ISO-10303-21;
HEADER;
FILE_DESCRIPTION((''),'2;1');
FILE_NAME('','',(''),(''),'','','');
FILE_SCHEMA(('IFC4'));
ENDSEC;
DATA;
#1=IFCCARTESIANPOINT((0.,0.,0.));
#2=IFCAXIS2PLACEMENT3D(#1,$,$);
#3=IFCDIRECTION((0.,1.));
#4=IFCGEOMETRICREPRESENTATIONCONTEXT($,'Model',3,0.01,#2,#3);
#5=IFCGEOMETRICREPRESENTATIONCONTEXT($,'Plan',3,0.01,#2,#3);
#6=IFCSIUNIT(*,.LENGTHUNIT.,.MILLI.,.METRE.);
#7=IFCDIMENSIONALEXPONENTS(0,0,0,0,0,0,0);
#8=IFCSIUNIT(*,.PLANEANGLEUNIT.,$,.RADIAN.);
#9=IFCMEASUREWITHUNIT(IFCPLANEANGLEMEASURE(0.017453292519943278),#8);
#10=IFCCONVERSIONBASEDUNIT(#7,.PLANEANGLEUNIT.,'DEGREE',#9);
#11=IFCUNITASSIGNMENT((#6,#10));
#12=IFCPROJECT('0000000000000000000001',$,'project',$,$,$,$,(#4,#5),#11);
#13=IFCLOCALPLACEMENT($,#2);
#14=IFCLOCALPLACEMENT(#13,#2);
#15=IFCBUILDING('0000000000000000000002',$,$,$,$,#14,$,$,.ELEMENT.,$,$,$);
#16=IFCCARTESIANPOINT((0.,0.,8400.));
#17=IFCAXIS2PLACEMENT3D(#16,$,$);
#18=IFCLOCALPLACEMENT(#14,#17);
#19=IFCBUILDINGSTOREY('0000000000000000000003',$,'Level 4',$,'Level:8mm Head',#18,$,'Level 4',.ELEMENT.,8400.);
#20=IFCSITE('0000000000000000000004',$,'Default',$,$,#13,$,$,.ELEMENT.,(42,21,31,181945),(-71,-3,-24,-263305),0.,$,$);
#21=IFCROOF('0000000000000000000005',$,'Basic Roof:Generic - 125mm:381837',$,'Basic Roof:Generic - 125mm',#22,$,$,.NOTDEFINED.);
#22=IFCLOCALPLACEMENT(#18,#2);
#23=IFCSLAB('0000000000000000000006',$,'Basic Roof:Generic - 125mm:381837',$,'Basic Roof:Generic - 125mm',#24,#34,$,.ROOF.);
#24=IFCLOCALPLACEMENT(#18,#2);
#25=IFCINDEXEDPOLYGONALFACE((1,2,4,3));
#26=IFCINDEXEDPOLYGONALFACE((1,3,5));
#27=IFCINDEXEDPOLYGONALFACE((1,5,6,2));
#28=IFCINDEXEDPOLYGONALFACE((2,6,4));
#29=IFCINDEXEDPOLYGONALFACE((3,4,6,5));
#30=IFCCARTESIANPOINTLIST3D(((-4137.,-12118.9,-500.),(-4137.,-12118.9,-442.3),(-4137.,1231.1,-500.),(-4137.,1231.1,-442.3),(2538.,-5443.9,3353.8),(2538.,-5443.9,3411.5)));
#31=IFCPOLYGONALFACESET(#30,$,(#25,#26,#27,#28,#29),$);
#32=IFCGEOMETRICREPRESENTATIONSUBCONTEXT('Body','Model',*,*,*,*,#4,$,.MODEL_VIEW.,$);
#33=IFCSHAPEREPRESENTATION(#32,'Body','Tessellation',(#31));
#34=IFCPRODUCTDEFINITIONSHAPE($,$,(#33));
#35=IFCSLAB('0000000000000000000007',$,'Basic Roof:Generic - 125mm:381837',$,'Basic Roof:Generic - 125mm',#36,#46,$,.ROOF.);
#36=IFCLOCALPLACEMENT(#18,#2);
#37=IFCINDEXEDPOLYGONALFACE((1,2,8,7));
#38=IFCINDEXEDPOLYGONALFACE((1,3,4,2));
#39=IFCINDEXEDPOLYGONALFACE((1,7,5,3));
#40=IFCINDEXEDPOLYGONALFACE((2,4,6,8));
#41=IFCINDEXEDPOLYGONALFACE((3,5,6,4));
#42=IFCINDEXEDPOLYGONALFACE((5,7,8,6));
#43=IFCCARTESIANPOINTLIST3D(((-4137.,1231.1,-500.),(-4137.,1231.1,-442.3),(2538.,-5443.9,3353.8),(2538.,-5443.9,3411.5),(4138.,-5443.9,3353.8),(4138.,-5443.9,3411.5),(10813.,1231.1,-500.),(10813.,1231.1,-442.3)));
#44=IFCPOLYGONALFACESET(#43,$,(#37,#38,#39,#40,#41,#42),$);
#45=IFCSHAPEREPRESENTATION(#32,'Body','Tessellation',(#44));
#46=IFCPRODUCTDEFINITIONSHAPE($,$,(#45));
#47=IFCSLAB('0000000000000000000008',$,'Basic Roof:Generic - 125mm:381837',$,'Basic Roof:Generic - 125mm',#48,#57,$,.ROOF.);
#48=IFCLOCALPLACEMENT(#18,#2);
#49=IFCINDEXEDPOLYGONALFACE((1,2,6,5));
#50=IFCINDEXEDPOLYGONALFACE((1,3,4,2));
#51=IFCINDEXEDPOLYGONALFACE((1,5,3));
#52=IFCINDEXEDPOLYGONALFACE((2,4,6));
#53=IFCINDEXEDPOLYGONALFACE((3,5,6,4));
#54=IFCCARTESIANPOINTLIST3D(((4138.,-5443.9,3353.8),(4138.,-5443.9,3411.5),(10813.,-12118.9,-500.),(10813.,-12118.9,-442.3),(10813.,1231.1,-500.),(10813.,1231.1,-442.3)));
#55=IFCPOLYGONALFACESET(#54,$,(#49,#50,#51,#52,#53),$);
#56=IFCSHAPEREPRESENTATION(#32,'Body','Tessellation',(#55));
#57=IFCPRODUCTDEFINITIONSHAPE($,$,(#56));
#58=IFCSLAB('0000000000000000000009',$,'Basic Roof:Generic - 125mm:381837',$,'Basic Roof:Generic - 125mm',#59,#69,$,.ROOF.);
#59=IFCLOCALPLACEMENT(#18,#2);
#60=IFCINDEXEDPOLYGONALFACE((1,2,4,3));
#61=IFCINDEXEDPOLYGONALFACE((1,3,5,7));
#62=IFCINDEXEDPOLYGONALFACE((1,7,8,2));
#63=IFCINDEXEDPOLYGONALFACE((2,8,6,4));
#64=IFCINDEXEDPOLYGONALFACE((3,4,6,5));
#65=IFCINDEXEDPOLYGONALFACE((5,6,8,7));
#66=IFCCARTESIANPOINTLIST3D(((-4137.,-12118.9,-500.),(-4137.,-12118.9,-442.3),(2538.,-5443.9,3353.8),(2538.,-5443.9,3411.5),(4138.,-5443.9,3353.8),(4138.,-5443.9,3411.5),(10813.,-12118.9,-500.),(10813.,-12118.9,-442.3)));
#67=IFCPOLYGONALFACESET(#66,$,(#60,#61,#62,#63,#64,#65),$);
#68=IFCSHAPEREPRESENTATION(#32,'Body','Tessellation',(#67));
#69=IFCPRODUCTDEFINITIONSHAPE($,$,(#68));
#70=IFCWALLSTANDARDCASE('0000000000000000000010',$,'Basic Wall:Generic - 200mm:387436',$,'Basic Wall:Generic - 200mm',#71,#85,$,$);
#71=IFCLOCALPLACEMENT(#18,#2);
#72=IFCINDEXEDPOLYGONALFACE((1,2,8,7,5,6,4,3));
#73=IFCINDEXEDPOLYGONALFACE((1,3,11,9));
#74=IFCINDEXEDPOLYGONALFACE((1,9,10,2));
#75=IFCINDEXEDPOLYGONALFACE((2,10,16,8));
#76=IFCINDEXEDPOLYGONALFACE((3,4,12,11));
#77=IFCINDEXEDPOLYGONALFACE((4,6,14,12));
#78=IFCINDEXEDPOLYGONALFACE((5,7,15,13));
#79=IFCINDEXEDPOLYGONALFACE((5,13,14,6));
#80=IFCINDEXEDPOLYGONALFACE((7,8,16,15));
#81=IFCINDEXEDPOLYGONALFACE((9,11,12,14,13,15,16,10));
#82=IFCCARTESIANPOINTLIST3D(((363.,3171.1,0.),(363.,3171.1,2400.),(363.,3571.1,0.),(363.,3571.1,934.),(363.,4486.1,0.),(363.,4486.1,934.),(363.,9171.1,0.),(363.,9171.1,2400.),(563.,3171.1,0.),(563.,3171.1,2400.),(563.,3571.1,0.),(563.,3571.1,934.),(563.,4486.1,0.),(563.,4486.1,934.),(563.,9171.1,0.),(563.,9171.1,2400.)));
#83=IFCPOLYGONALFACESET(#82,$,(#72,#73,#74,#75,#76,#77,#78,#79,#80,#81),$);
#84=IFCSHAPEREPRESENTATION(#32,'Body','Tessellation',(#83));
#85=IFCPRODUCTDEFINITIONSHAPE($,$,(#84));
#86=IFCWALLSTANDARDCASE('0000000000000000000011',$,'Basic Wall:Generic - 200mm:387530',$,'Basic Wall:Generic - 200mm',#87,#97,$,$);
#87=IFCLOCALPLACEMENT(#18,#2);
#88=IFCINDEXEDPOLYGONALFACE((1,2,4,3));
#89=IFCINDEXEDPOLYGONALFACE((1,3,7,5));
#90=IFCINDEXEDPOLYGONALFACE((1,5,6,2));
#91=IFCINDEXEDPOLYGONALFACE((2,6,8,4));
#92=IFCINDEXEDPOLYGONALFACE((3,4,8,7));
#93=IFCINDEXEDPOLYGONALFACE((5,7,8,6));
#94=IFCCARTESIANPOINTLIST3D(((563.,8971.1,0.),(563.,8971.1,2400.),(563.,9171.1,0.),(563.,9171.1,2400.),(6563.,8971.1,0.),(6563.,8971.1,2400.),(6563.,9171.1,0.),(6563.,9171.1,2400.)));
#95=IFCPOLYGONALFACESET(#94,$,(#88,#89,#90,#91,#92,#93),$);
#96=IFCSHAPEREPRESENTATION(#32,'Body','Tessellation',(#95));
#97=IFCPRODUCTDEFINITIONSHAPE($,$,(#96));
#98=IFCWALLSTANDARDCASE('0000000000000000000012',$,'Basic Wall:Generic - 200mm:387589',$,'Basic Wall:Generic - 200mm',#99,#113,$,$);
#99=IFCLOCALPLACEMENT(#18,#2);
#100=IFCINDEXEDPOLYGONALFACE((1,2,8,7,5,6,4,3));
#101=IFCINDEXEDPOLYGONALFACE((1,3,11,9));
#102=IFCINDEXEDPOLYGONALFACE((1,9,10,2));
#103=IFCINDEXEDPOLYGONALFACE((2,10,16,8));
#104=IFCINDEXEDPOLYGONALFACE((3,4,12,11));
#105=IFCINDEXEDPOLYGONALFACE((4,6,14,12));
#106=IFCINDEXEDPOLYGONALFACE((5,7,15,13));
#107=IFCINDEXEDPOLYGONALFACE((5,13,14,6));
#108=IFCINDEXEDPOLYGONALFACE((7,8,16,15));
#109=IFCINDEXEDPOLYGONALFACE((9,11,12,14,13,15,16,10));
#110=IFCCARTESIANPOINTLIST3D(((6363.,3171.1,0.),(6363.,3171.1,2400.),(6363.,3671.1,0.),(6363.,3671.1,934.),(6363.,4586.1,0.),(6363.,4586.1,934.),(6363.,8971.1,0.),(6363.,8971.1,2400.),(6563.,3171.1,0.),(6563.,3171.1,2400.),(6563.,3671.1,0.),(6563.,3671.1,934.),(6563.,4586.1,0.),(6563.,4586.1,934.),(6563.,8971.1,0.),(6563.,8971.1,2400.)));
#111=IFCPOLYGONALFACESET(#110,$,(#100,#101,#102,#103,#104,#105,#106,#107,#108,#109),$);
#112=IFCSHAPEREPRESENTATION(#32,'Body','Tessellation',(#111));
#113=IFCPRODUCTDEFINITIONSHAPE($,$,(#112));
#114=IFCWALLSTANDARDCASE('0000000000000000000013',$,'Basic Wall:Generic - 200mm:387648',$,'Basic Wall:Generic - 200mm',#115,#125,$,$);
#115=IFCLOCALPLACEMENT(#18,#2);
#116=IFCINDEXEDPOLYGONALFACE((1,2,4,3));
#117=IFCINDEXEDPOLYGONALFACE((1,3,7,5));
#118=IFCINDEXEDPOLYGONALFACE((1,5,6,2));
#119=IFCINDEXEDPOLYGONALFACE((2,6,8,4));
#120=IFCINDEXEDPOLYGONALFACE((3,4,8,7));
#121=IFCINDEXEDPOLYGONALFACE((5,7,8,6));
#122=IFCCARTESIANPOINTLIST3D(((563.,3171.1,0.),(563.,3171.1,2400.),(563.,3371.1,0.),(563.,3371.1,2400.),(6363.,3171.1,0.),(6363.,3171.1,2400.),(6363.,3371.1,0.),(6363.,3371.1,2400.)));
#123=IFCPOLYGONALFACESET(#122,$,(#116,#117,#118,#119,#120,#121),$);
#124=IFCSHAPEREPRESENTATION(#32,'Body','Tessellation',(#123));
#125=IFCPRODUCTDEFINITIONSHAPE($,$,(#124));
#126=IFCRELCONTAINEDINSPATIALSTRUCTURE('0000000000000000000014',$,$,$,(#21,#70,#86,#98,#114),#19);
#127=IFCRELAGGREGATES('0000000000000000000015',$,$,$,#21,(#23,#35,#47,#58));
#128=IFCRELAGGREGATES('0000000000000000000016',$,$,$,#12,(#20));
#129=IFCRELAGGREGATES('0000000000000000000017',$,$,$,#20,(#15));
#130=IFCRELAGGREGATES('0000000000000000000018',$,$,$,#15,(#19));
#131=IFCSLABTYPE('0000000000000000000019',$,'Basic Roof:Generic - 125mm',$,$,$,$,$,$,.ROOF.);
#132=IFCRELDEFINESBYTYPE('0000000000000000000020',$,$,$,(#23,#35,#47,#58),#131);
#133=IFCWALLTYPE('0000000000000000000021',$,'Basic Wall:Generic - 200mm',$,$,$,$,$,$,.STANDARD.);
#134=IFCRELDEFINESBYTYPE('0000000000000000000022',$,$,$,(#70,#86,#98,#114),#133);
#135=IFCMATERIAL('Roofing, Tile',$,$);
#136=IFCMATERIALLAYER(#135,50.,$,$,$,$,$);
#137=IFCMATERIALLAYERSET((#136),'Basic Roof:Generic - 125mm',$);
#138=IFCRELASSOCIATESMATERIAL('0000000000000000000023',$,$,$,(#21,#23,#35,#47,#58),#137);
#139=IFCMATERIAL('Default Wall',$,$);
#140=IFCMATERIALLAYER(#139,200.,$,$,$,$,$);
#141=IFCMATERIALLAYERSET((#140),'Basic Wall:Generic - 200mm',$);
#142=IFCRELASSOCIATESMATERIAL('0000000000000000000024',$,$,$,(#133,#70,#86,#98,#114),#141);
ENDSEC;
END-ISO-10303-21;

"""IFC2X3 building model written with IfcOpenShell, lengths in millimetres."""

from ifc_helpers import new_model, entity, si_unit, converted_unit, direction, frame, frame_2d, origin, origin_2d_with_axis, place, context, subcontext, project, spatial, polyline, rectangle, outline, extrude, clip, halfspace, material, layer, layer_set, layer_usage, type_object, element, aggregate, save


model = new_model("IFC2X3")

# Units and contexts
model_context = context("Model", 3, precision=0.01, world=origin(), true_north=direction((0.0, 1.0)))
plan_context = context("Plan", 3, precision=0.01, world=origin(), true_north=direction((0.0, 1.0)))
body_context = subcontext(model_context, "Body", "Model", "MODEL_VIEW")
ifc_project = project(units=[si_unit("LENGTHUNIT", "METRE", prefix="MILLI"), converted_unit("PLANEANGLEUNIT", "DEGREE", entity("IfcPlaneAngleMeasure", 0.017453292519943278), si_unit("PLANEANGLEUNIT", "RADIAN"), dimensions=[0, 0, 0, 0, 0, 0, 0])], contexts=[model_context, plan_context])

# Site, building, storey
site_placement = place(None, origin())
site = spatial("IfcSite", under=ifc_project, at=site_placement, Name="Default", CompositionType="ELEMENT", RefLatitude=(42, 21, 31, 181945), RefLongitude=(-71, -3, -24, -263305), RefElevation=0.0)
building_placement = place(site_placement, origin())
building = spatial("IfcBuilding", under=site, at=building_placement, CompositionType="ELEMENT")
storey_placement = place(building_placement, frame((0.0, 0.0, 8400.0)))
storey = spatial("IfcBuildingStorey", under=building, at=storey_placement, Name="Level 4", ObjectType="Level:8mm Head", LongName="Level 4", CompositionType="ELEMENT", Elevation=8400.0)

# Roof, slabs
ifc_material_1 = material(Name="Roofing, Tile")
ifc_layer_1 = layer(ifc_material_1, 50.0)
ifc_layer_set_1 = layer_set([ifc_layer_1], Name="Basic Roof:Generic - 125mm")
roof_placement = place(storey_placement, frame((-4137.0, -12118.9, -500.0)))
roof = element("IfcRoof", 1, at=roof_placement, inside=storey, material=ifc_layer_set_1, Name="Basic Roof:Generic - 125mm:381837", ObjectType="Basic Roof:Generic - 125mm", ShapeType="NOTDEFINED")
slab_type = type_object("IfcSlabType", Name="Basic Roof:Generic - 125mm", PredefinedType="ROOF")
slab_1_placement = place(roof_placement, origin())
slab_1 = element("IfcSlab", 2, at=slab_1_placement, type_object=slab_type, material=ifc_layer_set_1, Name="Basic Roof:Generic - 125mm:381837", ObjectType="Basic Roof:Generic - 125mm", PredefinedType="ROOF", context=body_context, shape_type="SweptSolid", body=[
    extrude(outline(polyline([(-3853.8, 6675.0), (-3853.8, -6675.0), (3853.8, 0.0), (-3853.8, 6675.0)])), frame((3337.5, 6675.0, 1926.9), z_axis=(-0.5, 0.0, 0.866025), x_axis=(0.866025, 0.0, 0.5)), (0.5, 0.0, 0.866025), 57.7),
])
slab_2_placement = place(roof_placement, origin())
slab_2 = element("IfcSlab", 3, at=slab_2_placement, type_object=slab_type, material=ifc_layer_set_1, Name="Basic Roof:Generic - 125mm:381837", ObjectType="Basic Roof:Generic - 125mm", PredefinedType="ROOF", context=body_context, shape_type="SweptSolid", body=[
    extrude(outline(polyline([(-800.0, -3853.8), (800.0, -3853.8), (7475.0, 3853.8), (-7475.0, 3853.8), (-800.0, -3853.8)])), frame((7475.0, 10012.5, 1926.9), z_axis=(0.0, 0.5, 0.866025), x_axis=(1.0, 0.0, 0.0)), (0.0, -0.5, 0.866025), 57.7),
])
slab_3_placement = place(roof_placement, origin())
slab_3 = element("IfcSlab", 4, at=slab_3_placement, type_object=slab_type, material=ifc_layer_set_1, Name="Basic Roof:Generic - 125mm:381837", ObjectType="Basic Roof:Generic - 125mm", PredefinedType="ROOF", context=body_context, shape_type="SweptSolid", body=[
    extrude(outline(polyline([(3853.8, -6675.0), (3853.8, 6675.0), (-3853.8, 0.0), (3853.8, -6675.0)])), frame((11612.5, 6675.0, 1926.9), z_axis=(0.5, 0.0, 0.866025), x_axis=(0.866025, 0.0, -0.5)), (-0.5, 0.0, 0.866025), 57.7),
])
slab_4_placement = place(roof_placement, origin())
slab_4 = element("IfcSlab", 5, at=slab_4_placement, type_object=slab_type, material=ifc_layer_set_1, Name="Basic Roof:Generic - 125mm:381837", ObjectType="Basic Roof:Generic - 125mm", PredefinedType="ROOF", context=body_context, shape_type="SweptSolid", body=[
    extrude(outline(polyline([(-7475.0, -3853.8), (7475.0, -3853.8), (800.0, 3853.8), (-800.0, 3853.8), (-7475.0, -3853.8)])), frame((7475.0, 3337.5, 1926.9), z_axis=(0.0, -0.5, 0.866025), x_axis=(1.0, 0.0, 0.0)), (0.0, 0.5, 0.866025), 57.7),
])
aggregate(roof, [slab_1, slab_2, slab_3, slab_4])

# Wall, opening
ifc_material_2 = material(Name="Default Wall")
ifc_layer_2 = layer(ifc_material_2, 200.0)
ifc_layer_set_2 = layer_set([ifc_layer_2], Name="Basic Wall:Generic - 200mm")
ifc_layer_usage_1 = layer_usage(ifc_layer_set_2, "AXIS2", "NEGATIVE", 100.0)
wall_type = type_object("IfcWallType", Name="Basic Wall:Generic - 200mm", PredefinedType="STANDARD", material=ifc_layer_set_2)
wall_1_placement = place(storey_placement, frame((463.0, 3171.1, 0.0), z_axis=(0.0, 0.0, 1.0), x_axis=(0.0, 1.0, 0.0)))
wall_1 = element("IfcWallStandardCase", 6, at=wall_1_placement, inside=storey, type_object=wall_type, material=ifc_layer_usage_1, Name="Basic Wall:Generic - 200mm:387436", ObjectType="Basic Wall:Generic - 200mm", context=body_context, shape_type="Clipping", body=[
    clip(extrude(rectangle(XDim=6000.0, YDim=200.0, at=frame_2d((3000.0, 0.0), x_axis=(1.0, 0.0))), origin(), (0.0, 0.0, 1.0), 2400.0), halfspace(frame((0.0, 0.0, -1200.0)), True)),
])
opening_1_placement = place(wall_1_placement, frame((-3171.1, 463.0, -1200.0), z_axis=(0.0, 0.0, 1.0), x_axis=(0.0, -1.0, 0.0)))
element("IfcOpeningElement", 7, at=opening_1_placement, cuts=wall_1, ObjectType="Opening", context=body_context, shape_type="SweptSolid", body=[
    extrude(rectangle(XDim=2134.0, YDim=915.0, at=origin_2d_with_axis()), frame((2087.0, 4028.6, 1067.0), z_axis=(-1.0, 0.0, 0.0), x_axis=(0.0, 0.0, 1.0)), (0.0, 0.0, 1.0), 3048.0),
])

# Wall
ifc_layer_usage_2 = layer_usage(ifc_layer_set_2, "AXIS2", "NEGATIVE", 100.0)
wall_2_placement = place(storey_placement, frame((563.0, 9071.1, 0.0)))
element("IfcWallStandardCase", 8, at=wall_2_placement, inside=storey, type_object=wall_type, material=ifc_layer_usage_2, Name="Basic Wall:Generic - 200mm:387530", ObjectType="Basic Wall:Generic - 200mm", context=body_context, shape_type="Clipping", body=[
    clip(extrude(rectangle(XDim=6000.0, YDim=200.0, at=frame_2d((3000.0, 0.0), x_axis=(-1.0, 0.0))), origin(), (0.0, 0.0, 1.0), 2400.0), halfspace(frame((0.0, 0.0, -1200.0)), True)),
])

# Wall, opening
ifc_layer_usage_3 = layer_usage(ifc_layer_set_2, "AXIS2", "NEGATIVE", 100.0)
wall_3_placement = place(storey_placement, frame((6463.0, 8971.1, 0.0), z_axis=(0.0, 0.0, 1.0), x_axis=(0.0, -1.0, 0.0)))
wall_3 = element("IfcWallStandardCase", 9, at=wall_3_placement, inside=storey, type_object=wall_type, material=ifc_layer_usage_3, Name="Basic Wall:Generic - 200mm:387589", ObjectType="Basic Wall:Generic - 200mm", context=body_context, shape_type="Clipping", body=[
    clip(extrude(rectangle(XDim=5800.0, YDim=200.0, at=frame_2d((2900.0, 0.0), x_axis=(1.0, 0.0))), origin(), (0.0, 0.0, 1.0), 2400.0), halfspace(frame((0.0, 0.0, -1200.0)), True)),
])
opening_2_placement = place(wall_3_placement, frame((8971.1, -6463.0, -1200.0), z_axis=(0.0, 0.0, 1.0), x_axis=(0.0, 1.0, 0.0)))
element("IfcOpeningElement", 10, at=opening_2_placement, cuts=wall_3, ObjectType="Opening", context=body_context, shape_type="SweptSolid", body=[
    extrude(rectangle(XDim=2134.0, YDim=915.0, at=frame_2d((0.0, 0.0), x_axis=(1.0, 0.0))), frame((4839.0, 4128.6, 1067.0), z_axis=(1.0, 0.0, 0.0), x_axis=(0.0, 0.0, 1.0)), (0.0, 0.0, 1.0), 3048.0),
])

# Wall
ifc_layer_usage_4 = layer_usage(ifc_layer_set_2, "AXIS2", "NEGATIVE", 100.0)
wall_4_placement = place(storey_placement, frame((6363.0, 3271.1, 0.0), z_axis=(0.0, 0.0, 1.0), x_axis=(-1.0, 0.0, 0.0)))
element("IfcWallStandardCase", 11, at=wall_4_placement, inside=storey, type_object=wall_type, material=ifc_layer_usage_4, Name="Basic Wall:Generic - 200mm:387648", ObjectType="Basic Wall:Generic - 200mm", context=body_context, shape_type="Clipping", body=[
    clip(extrude(rectangle(XDim=5800.0, YDim=200.0, at=frame_2d((2900.0, 0.0), x_axis=(-1.0, 0.0))), origin(), (0.0, 0.0, 1.0), 2400.0), halfspace(frame((0.0, 0.0, -1200.0)), True)),
])

save(model, "model.ifc")
